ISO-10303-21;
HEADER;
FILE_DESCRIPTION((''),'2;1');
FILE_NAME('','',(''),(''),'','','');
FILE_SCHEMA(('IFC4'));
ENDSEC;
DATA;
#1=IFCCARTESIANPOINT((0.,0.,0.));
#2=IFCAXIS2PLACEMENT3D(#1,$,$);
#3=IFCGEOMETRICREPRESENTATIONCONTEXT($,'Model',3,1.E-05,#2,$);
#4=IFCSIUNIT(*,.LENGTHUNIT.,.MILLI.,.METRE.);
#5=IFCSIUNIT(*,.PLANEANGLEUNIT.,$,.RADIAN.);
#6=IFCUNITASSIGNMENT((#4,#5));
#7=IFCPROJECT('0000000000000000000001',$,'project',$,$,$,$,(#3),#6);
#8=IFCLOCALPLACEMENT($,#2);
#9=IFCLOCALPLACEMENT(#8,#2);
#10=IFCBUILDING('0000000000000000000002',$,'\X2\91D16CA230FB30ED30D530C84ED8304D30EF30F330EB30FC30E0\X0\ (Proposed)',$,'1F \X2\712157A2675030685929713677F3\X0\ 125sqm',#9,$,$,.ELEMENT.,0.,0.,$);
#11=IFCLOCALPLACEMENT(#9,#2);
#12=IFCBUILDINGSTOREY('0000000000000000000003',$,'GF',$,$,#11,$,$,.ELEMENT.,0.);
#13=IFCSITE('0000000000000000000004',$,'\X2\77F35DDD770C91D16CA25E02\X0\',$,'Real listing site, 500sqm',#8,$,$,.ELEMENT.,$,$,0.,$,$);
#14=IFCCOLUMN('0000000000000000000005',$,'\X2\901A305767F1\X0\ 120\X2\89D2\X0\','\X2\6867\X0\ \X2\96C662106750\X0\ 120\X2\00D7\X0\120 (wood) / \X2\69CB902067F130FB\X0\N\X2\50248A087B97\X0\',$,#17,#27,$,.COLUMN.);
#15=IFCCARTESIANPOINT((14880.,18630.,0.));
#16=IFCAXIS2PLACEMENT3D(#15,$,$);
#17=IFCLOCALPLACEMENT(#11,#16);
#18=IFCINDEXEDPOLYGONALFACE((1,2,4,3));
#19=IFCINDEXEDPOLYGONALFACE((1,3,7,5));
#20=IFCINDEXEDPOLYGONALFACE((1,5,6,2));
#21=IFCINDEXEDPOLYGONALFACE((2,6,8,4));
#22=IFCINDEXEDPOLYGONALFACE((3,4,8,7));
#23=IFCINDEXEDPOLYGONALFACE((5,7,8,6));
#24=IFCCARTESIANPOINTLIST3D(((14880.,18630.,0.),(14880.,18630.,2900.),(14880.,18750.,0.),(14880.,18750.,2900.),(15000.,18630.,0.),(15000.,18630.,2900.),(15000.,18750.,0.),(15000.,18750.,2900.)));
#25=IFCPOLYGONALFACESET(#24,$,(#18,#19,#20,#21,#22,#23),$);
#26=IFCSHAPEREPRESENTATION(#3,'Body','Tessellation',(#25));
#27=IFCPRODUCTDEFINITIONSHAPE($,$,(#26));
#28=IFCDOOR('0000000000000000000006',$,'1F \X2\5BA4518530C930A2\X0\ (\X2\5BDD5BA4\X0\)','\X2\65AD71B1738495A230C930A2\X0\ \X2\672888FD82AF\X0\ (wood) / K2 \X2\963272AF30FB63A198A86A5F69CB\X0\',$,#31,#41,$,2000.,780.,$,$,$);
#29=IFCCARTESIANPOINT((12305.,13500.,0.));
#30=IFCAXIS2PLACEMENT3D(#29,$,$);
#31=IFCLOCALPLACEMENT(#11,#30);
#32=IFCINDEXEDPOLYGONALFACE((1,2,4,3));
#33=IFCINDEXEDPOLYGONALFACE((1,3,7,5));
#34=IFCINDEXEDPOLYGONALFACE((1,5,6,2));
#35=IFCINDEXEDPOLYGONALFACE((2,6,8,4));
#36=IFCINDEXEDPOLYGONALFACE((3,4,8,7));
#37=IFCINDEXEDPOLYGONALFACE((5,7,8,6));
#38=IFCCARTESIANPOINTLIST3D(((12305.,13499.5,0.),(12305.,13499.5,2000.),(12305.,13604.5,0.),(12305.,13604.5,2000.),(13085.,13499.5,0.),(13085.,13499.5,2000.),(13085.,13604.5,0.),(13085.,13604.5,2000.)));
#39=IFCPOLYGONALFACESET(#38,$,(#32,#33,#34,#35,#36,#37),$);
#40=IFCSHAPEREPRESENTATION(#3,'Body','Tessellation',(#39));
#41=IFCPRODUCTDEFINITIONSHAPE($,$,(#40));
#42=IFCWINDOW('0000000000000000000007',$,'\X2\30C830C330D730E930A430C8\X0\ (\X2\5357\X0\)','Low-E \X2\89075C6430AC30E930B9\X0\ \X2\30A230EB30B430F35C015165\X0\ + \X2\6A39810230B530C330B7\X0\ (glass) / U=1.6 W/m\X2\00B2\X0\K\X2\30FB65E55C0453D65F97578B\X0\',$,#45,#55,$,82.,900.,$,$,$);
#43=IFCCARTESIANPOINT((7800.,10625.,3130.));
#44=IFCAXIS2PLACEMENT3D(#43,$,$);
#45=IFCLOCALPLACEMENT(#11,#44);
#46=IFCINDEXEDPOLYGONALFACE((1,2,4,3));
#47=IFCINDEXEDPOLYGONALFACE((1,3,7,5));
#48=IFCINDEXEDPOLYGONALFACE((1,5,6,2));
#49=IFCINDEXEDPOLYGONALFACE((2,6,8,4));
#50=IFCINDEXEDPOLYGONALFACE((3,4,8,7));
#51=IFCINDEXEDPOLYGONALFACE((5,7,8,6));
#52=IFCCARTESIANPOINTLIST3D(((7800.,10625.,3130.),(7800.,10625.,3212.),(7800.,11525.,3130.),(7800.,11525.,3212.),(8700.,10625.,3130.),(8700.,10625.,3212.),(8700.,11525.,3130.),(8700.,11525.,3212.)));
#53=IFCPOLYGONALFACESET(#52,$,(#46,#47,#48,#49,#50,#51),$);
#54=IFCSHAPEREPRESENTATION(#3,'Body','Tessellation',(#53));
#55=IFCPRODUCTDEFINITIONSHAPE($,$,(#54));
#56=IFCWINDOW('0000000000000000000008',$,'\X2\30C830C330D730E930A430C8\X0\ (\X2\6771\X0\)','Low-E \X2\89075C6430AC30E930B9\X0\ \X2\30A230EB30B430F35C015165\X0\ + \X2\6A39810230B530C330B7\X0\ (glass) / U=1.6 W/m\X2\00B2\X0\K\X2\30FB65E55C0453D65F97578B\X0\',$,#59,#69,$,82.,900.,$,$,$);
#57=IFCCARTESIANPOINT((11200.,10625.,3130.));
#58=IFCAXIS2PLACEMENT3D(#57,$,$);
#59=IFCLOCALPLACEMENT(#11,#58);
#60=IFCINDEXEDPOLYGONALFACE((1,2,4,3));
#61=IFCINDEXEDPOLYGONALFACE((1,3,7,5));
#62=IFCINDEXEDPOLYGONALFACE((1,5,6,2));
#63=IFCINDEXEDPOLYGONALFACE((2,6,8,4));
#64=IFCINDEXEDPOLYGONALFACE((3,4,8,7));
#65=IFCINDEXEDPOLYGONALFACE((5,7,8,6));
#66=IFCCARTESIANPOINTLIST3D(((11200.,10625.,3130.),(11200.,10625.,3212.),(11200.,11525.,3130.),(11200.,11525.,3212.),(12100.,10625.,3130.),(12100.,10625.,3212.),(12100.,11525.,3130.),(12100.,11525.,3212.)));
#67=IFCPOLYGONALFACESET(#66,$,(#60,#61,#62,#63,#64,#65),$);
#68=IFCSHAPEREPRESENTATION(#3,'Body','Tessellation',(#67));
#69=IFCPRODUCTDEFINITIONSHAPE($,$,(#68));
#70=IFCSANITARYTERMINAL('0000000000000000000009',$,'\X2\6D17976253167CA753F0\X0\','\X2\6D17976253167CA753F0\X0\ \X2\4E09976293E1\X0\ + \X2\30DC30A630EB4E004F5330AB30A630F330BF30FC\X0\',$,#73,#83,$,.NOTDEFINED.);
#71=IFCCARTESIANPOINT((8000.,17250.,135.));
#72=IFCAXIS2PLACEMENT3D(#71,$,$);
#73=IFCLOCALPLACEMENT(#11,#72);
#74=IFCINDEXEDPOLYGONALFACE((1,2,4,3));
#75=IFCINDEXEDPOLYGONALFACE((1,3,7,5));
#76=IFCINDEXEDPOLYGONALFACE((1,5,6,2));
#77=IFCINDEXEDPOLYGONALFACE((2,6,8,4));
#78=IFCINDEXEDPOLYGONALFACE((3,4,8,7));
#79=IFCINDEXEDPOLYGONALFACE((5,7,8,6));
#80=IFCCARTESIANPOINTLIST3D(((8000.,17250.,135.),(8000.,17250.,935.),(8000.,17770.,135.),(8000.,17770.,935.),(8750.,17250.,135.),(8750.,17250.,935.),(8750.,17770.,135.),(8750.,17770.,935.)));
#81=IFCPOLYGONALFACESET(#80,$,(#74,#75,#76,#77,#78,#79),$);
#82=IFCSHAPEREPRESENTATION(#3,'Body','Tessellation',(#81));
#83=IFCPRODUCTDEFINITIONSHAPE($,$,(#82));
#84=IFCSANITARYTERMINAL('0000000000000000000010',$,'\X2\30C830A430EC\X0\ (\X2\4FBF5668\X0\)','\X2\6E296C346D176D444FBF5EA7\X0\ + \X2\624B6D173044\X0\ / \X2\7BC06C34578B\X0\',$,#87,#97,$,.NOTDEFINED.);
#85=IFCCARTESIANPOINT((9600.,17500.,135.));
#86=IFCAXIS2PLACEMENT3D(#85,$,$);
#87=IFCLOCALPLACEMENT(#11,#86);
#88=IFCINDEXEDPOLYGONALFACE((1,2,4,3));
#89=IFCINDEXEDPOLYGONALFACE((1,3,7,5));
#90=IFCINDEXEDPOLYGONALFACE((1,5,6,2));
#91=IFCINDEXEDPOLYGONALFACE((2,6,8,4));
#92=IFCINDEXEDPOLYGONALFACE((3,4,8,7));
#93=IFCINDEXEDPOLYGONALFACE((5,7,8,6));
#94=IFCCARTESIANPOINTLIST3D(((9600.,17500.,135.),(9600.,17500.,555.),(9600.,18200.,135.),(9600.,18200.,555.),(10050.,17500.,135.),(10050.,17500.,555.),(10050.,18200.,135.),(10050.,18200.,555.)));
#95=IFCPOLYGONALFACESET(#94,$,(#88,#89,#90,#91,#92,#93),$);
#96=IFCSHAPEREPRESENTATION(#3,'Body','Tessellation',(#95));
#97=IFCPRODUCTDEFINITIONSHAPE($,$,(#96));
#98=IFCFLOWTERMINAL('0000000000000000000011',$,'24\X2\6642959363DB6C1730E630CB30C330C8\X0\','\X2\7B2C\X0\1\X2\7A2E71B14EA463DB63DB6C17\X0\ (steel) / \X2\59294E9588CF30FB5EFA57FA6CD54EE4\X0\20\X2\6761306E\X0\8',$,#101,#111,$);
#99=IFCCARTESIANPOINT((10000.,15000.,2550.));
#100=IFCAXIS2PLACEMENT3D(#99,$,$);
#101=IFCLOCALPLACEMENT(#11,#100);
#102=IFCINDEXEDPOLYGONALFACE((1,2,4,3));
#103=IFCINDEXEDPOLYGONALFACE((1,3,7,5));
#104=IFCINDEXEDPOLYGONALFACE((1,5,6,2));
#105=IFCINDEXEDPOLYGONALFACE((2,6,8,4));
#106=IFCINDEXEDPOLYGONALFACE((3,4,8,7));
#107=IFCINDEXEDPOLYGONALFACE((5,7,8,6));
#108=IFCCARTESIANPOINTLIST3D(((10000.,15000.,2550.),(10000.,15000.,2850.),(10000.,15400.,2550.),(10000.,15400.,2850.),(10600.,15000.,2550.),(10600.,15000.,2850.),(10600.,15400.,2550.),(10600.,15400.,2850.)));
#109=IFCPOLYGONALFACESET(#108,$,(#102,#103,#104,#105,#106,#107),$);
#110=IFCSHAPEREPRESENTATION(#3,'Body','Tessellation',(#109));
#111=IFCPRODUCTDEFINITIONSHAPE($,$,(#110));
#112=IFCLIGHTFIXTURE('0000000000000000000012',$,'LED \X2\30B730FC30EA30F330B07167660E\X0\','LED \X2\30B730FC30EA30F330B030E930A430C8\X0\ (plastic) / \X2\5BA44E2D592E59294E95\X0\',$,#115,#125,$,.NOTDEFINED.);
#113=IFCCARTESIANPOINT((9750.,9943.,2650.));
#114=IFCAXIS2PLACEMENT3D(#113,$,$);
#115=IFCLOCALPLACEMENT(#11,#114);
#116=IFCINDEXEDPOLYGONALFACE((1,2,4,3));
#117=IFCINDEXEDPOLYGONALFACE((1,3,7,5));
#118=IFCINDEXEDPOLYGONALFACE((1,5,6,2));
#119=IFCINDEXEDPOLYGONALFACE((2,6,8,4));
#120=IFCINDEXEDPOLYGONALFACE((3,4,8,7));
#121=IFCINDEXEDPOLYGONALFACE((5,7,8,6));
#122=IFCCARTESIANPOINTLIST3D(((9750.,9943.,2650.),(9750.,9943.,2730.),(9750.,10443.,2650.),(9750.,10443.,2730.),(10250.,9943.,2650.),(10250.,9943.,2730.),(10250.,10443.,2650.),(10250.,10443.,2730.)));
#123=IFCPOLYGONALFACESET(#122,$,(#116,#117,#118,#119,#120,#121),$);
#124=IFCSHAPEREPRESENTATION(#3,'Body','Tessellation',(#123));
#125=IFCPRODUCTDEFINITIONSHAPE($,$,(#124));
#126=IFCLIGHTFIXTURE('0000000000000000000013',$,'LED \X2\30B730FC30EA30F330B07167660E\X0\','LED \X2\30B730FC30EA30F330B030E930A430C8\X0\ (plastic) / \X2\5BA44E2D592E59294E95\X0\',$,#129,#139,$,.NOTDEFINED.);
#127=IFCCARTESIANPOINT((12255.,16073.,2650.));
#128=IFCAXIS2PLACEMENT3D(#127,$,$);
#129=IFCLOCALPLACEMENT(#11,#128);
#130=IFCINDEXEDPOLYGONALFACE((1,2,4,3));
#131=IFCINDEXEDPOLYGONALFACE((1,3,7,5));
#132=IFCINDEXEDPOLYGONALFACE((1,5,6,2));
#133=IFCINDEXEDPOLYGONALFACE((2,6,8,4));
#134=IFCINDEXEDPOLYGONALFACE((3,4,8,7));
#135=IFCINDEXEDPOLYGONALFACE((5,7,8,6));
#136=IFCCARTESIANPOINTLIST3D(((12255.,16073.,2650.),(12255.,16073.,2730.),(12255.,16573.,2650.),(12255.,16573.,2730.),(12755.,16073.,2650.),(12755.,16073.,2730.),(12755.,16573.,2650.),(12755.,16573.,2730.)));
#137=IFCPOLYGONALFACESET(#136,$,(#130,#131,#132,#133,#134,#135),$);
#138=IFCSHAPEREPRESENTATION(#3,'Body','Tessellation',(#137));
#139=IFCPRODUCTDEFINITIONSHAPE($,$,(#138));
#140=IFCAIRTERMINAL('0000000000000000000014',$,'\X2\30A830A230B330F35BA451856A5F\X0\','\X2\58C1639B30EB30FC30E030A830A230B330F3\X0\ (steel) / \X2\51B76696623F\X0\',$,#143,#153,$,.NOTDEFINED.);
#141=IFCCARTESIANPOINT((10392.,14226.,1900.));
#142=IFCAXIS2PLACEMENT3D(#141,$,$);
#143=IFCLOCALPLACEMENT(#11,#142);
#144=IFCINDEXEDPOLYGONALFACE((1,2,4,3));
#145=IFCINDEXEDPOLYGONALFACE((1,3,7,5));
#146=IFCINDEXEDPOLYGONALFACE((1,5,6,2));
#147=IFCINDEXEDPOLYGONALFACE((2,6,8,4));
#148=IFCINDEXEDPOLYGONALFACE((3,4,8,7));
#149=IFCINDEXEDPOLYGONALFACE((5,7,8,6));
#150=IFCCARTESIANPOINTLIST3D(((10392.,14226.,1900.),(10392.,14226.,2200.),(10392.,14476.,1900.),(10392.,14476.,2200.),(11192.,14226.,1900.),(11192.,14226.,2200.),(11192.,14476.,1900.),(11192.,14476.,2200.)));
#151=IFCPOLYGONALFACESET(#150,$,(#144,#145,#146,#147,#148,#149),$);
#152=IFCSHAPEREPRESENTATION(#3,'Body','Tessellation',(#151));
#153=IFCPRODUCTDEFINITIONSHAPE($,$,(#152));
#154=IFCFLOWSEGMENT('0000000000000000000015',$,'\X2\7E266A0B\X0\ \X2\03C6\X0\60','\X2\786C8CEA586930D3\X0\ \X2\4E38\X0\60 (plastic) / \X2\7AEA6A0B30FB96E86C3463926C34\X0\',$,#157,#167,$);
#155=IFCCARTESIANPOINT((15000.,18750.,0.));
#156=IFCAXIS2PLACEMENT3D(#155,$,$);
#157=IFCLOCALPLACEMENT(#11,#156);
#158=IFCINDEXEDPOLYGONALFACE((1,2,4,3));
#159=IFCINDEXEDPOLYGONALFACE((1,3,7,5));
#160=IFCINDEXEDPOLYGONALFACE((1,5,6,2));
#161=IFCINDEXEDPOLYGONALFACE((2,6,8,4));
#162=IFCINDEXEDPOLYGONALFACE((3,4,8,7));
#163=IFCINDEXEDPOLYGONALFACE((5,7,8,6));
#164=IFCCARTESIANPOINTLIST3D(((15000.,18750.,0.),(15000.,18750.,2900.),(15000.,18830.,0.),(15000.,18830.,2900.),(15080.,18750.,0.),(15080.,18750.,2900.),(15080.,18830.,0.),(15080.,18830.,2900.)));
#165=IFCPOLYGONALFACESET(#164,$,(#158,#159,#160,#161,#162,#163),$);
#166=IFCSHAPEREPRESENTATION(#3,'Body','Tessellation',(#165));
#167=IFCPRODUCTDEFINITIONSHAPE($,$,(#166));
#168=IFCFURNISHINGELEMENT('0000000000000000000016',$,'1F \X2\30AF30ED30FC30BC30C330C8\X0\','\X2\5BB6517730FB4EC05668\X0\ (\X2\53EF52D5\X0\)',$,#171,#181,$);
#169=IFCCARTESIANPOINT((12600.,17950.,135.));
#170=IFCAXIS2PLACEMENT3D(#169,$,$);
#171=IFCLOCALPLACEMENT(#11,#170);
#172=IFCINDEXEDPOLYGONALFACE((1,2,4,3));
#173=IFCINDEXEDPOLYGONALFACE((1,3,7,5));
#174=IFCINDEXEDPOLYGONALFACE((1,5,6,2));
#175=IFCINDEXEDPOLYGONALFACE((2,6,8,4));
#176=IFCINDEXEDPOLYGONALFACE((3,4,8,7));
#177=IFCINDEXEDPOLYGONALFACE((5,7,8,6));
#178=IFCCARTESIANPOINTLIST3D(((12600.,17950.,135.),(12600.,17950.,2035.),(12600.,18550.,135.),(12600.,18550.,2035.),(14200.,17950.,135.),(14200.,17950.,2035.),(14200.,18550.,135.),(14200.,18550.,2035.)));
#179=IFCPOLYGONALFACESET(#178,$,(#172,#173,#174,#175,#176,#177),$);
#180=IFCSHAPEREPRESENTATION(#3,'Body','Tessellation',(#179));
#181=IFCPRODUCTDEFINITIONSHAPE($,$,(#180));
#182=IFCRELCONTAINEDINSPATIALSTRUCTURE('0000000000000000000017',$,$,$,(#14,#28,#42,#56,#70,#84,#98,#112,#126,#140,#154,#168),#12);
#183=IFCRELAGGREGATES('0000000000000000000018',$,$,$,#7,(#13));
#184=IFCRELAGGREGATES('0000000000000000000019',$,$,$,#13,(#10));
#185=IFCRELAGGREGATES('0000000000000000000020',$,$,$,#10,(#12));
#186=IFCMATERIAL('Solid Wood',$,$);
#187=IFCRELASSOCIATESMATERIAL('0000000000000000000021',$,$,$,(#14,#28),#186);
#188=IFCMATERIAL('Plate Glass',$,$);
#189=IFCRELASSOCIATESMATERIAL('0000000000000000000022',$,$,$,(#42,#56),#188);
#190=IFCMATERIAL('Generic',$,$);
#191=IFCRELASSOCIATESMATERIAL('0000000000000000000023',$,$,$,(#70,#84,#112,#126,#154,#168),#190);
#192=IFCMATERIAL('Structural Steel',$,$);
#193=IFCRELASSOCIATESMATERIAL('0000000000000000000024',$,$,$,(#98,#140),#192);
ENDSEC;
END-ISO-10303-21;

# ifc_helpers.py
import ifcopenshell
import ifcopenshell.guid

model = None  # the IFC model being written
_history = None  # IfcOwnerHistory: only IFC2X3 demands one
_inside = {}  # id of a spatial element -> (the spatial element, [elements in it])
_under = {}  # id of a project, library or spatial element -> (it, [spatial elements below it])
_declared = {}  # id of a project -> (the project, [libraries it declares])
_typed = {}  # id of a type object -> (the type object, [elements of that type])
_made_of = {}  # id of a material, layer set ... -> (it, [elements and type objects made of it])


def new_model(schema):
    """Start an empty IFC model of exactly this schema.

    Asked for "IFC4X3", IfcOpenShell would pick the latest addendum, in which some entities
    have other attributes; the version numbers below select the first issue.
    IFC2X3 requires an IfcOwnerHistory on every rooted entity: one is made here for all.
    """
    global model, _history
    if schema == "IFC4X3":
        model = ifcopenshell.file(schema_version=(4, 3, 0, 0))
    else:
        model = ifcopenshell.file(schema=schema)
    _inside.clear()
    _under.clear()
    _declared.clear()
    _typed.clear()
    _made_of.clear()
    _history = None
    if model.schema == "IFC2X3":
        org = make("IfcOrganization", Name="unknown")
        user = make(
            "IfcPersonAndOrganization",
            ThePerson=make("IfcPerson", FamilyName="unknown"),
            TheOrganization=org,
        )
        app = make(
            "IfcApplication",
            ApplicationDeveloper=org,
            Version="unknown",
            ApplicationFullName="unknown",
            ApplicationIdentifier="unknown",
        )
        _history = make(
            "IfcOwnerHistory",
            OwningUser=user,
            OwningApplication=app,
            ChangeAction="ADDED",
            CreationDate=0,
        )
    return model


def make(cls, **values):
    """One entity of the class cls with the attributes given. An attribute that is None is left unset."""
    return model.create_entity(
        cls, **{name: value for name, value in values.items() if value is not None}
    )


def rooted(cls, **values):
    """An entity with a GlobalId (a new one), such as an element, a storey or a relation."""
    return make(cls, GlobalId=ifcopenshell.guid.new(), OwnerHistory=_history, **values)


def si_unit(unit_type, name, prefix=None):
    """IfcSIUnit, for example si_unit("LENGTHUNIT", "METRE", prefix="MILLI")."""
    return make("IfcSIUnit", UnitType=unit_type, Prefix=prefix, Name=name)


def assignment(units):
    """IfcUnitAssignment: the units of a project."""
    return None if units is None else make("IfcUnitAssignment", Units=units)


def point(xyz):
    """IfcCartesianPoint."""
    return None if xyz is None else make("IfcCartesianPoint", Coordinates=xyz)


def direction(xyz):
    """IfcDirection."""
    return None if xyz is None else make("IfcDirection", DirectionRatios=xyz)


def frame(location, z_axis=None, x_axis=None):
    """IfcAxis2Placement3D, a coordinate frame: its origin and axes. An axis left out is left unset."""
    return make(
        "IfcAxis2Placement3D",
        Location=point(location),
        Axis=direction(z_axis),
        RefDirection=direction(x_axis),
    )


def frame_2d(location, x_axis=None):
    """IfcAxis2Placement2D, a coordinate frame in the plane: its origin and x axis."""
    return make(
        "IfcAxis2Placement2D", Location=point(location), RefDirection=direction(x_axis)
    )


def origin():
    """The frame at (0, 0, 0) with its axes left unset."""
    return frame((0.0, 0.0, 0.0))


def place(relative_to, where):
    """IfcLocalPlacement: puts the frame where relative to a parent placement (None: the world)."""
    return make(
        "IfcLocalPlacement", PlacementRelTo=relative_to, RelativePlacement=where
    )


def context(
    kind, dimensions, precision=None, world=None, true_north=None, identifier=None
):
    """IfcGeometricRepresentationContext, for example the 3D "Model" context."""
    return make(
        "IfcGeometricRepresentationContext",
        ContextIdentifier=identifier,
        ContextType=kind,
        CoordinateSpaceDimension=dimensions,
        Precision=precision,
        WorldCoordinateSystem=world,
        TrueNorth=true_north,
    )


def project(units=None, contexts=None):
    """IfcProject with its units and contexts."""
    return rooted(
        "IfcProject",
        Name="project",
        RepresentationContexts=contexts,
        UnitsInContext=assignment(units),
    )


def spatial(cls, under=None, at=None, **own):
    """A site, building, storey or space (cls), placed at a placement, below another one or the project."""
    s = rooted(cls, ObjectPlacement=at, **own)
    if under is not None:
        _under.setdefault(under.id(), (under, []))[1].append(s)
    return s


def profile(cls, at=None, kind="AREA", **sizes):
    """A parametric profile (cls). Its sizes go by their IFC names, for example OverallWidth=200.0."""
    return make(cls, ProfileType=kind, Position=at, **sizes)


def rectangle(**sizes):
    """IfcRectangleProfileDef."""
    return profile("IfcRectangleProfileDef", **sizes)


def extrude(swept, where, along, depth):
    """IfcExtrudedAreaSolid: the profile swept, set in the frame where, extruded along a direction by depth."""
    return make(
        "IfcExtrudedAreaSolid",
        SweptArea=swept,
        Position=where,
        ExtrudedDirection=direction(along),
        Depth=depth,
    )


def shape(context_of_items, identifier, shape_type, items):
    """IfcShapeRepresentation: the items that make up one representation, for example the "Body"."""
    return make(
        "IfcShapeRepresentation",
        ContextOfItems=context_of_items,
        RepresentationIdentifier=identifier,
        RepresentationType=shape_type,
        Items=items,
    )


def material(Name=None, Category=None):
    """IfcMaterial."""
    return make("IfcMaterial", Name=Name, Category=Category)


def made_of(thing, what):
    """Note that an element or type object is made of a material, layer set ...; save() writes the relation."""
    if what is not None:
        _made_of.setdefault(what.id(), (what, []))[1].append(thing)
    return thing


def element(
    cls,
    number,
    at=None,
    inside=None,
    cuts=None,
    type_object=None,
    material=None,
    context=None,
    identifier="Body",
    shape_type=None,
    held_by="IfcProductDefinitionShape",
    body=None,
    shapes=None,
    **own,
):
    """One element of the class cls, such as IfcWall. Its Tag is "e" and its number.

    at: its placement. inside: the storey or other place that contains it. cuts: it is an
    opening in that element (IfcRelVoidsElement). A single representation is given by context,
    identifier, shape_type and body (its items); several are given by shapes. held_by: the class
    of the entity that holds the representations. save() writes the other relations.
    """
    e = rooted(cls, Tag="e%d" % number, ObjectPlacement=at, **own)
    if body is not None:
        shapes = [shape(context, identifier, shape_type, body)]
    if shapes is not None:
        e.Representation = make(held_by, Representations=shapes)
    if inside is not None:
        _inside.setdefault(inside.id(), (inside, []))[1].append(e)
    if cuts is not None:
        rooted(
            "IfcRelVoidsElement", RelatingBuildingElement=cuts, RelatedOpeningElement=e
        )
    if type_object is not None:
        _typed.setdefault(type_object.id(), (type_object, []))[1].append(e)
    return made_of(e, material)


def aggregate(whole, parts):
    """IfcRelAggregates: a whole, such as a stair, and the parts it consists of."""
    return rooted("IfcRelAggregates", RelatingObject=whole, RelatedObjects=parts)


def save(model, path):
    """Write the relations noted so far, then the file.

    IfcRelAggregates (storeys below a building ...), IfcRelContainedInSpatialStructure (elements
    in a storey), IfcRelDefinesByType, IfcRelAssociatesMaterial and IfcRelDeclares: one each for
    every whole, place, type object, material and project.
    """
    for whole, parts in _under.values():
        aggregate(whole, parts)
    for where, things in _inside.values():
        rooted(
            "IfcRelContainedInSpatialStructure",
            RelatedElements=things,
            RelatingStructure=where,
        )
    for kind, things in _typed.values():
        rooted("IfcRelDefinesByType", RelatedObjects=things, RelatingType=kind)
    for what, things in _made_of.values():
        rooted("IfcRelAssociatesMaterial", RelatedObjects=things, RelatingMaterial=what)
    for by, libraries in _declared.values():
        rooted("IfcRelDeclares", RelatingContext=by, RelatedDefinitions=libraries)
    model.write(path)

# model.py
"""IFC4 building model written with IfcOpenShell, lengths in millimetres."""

from ifc_helpers import new_model, si_unit, frame, frame_2d, origin, place, context, project, spatial, rectangle, extrude, material, element, save


model = new_model("IFC4")

# Units and contexts
model_context = context("Model", 3, precision=1e-05, world=origin())
ifc_project = project(units=[si_unit("LENGTHUNIT", "METRE", prefix="MILLI"), si_unit("PLANEANGLEUNIT", "RADIAN")], contexts=[model_context])

# Site, building, storey
site_placement = place(None, origin())
site = spatial("IfcSite", under=ifc_project, at=site_placement, Name="石川県金沢市", ObjectType="Real listing site, 500sqm", CompositionType="ELEMENT", RefElevation=0.0)
building_placement = place(site_placement, origin())
building = spatial("IfcBuilding", under=site, at=building_placement, Name="金沢・ロフト付きワンルーム (Proposed)", ObjectType="1F 無垢材と天然石 125sqm", CompositionType="ELEMENT", ElevationOfRefHeight=0.0, ElevationOfTerrain=0.0)
storey_placement = place(building_placement, origin())
storey = spatial("IfcBuildingStorey", under=building, at=storey_placement, Name="GF", CompositionType="ELEMENT", Elevation=0.0)

# Column
ifc_material_1 = material(Name="Solid Wood")
column_1_placement = place(storey_placement, frame((14880.0, 18630.0, 0.0)))
element("IfcColumn", 1, at=column_1_placement, inside=storey, material=ifc_material_1, Name="通し柱 120角", Description="桧 集成材 120×120 (wood) / 構造柱・N値計算", PredefinedType="COLUMN", context=model_context, shape_type="SweptSolid", body=[
    extrude(rectangle(XDim=120.0, YDim=120.0, at=frame_2d((60.0, 60.0))), frame((14880.0, 18630.0, 0.0)), (0.0, 0.0, 1.0), 2900.0),
])

# Door
door_placement = place(storey_placement, frame((12305.0, 13500.0, 0.0)))
element("IfcDoor", 2, at=door_placement, inside=storey, material=ifc_material_1, Name="1F 室内ドア (寝室)", Description="断熱玄関ドア 木製芯 (wood) / K2 防犯・採風機構", OverallHeight=2000.0, OverallWidth=780.0, context=model_context, shape_type="SweptSolid", body=[
    extrude(rectangle(XDim=780.0, YDim=105.0, at=frame_2d((390.0, 52.0))), frame((12305.0, 13500.0, 0.0)), (0.0, 0.0, 1.0), 2000.0),
])

# Windows
ifc_material_2 = material(Name="Plate Glass")
window_1_placement = place(storey_placement, frame((7800.0, 10625.0, 3130.0)))
element("IfcWindow", 3, at=window_1_placement, inside=storey, material=ifc_material_2, Name="トップライト (南)", Description="Low-E 複層ガラス アルゴン封入 + 樹脂サッシ (glass) / U=1.6 W/m²K・日射取得型", OverallHeight=82.0, OverallWidth=900.0, context=model_context, shape_type="SweptSolid", body=[
    extrude(rectangle(XDim=900.0, YDim=900.0, at=frame_2d((450.0, 450.0))), frame((7800.0, 10625.0, 3130.0)), (0.0, 0.0, 1.0), 82.0),
])
window_2_placement = place(storey_placement, frame((11200.0, 10625.0, 3130.0)))
element("IfcWindow", 4, at=window_2_placement, inside=storey, material=ifc_material_2, Name="トップライト (東)", Description="Low-E 複層ガラス アルゴン封入 + 樹脂サッシ (glass) / U=1.6 W/m²K・日射取得型", OverallHeight=82.0, OverallWidth=900.0, context=model_context, shape_type="SweptSolid", body=[
    extrude(rectangle(XDim=900.0, YDim=900.0, at=frame_2d((450.0, 450.0))), frame((11200.0, 10625.0, 3130.0)), (0.0, 0.0, 1.0), 82.0),
])

# Sanitary terminals
ifc_material_3 = material(Name="Generic")
sanitary_terminal_1_placement = place(storey_placement, frame((8000.0, 17250.0, 135.0)))
element("IfcSanitaryTerminal", 5, at=sanitary_terminal_1_placement, inside=storey, material=ifc_material_3, Name="洗面化粧台", Description="洗面化粧台 三面鏡 + ボウル一体カウンター", PredefinedType="NOTDEFINED", context=model_context, shape_type="SweptSolid", body=[
    extrude(rectangle(XDim=750.0, YDim=520.0, at=frame_2d((375.0, 260.0))), frame((8000.0, 17250.0, 135.0)), (0.0, 0.0, 1.0), 800.0),
])
sanitary_terminal_2_placement = place(storey_placement, frame((9600.0, 17500.0, 135.0)))
element("IfcSanitaryTerminal", 6, at=sanitary_terminal_2_placement, inside=storey, material=ifc_material_3, Name="トイレ (便器)", Description="温水洗浄便座 + 手洗い / 節水型", PredefinedType="NOTDEFINED", context=model_context, shape_type="SweptSolid", body=[
    extrude(rectangle(XDim=450.0, YDim=700.0, at=frame_2d((225.0, 350.0))), frame((9600.0, 17500.0, 135.0)), (0.0, 0.0, 1.0), 420.0),
])

# Flow terminal
ifc_material_4 = material(Name="Structural Steel")
flow_terminal_placement = place(storey_placement, frame((10000.0, 15000.0, 2550.0)))
element("IfcFlowTerminal", 7, at=flow_terminal_placement, inside=storey, material=ifc_material_4, Name="24時間換気ユニット", Description="第1種熱交換換気 (steel) / 天井裏・建基法令20条の8", context=model_context, shape_type="SweptSolid", body=[
    extrude(rectangle(XDim=600.0, YDim=400.0, at=frame_2d((300.0, 200.0))), frame((10000.0, 15000.0, 2550.0)), (0.0, 0.0, 1.0), 300.0),
])

# Light fixtures
light_fixture_1_placement = place(storey_placement, frame((9750.0, 9943.0, 2650.0)))
element("IfcLightFixture", 8, at=light_fixture_1_placement, inside=storey, material=ifc_material_3, Name="LED シーリング照明", Description="LED シーリングライト (plastic) / 室中央天井", PredefinedType="NOTDEFINED", context=model_context, shape_type="SweptSolid", body=[
    extrude(rectangle(XDim=500.0, YDim=500.0, at=frame_2d((250.0, 250.0))), frame((9750.0, 9943.0, 2650.0)), (0.0, 0.0, 1.0), 80.0),
])
light_fixture_2_placement = place(storey_placement, frame((12255.0, 16073.0, 2650.0)))
element("IfcLightFixture", 9, at=light_fixture_2_placement, inside=storey, material=ifc_material_3, Name="LED シーリング照明", Description="LED シーリングライト (plastic) / 室中央天井", PredefinedType="NOTDEFINED", context=model_context, shape_type="SweptSolid", body=[
    extrude(rectangle(XDim=500.0, YDim=500.0, at=frame_2d((250.0, 250.0))), frame((12255.0, 16073.0, 2650.0)), (0.0, 0.0, 1.0), 80.0),
])

# Air terminal
air_terminal_placement = place(storey_placement, frame((10392.0, 14226.0, 1900.0)))
element("IfcAirTerminal", 10, at=air_terminal_placement, inside=storey, material=ifc_material_4, Name="エアコン室内機", Description="壁掛ルームエアコン (steel) / 冷暖房", PredefinedType="NOTDEFINED", context=model_context, shape_type="SweptSolid", body=[
    extrude(rectangle(XDim=800.0, YDim=250.0, at=frame_2d((400.0, 125.0))), frame((10392.0, 14226.0, 1900.0)), (0.0, 0.0, 1.0), 300.0),
])

# Flow segment
flow_segment_placement = place(storey_placement, frame((15000.0, 18750.0, 0.0)))
element("IfcFlowSegment", 11, at=flow_segment_placement, inside=storey, material=ifc_material_3, Name="縦樋 φ60", Description="硬質塩ビ 丸60 (plastic) / 竪樋・雨水排水", context=model_context, shape_type="SweptSolid", body=[
    extrude(rectangle(XDim=80.0, YDim=80.0, at=frame_2d((40.0, 40.0))), frame((15000.0, 18750.0, 0.0)), (0.0, 0.0, 1.0), 2900.0),
])

# Furnishing element
furnishing_placement = place(storey_placement, frame((12600.0, 17950.0, 135.0)))
element("IfcFurnishingElement", 12, at=furnishing_placement, inside=storey, material=ifc_material_3, Name="1F クローゼット", Description="家具・什器 (可動)", context=model_context, shape_type="SweptSolid", body=[
    extrude(rectangle(XDim=1600.0, YDim=600.0, at=frame_2d((800.0, 300.0))), frame((12600.0, 17950.0, 135.0)), (0.0, 0.0, 1.0), 1900.0),
])

save(model, "model.ifc")
